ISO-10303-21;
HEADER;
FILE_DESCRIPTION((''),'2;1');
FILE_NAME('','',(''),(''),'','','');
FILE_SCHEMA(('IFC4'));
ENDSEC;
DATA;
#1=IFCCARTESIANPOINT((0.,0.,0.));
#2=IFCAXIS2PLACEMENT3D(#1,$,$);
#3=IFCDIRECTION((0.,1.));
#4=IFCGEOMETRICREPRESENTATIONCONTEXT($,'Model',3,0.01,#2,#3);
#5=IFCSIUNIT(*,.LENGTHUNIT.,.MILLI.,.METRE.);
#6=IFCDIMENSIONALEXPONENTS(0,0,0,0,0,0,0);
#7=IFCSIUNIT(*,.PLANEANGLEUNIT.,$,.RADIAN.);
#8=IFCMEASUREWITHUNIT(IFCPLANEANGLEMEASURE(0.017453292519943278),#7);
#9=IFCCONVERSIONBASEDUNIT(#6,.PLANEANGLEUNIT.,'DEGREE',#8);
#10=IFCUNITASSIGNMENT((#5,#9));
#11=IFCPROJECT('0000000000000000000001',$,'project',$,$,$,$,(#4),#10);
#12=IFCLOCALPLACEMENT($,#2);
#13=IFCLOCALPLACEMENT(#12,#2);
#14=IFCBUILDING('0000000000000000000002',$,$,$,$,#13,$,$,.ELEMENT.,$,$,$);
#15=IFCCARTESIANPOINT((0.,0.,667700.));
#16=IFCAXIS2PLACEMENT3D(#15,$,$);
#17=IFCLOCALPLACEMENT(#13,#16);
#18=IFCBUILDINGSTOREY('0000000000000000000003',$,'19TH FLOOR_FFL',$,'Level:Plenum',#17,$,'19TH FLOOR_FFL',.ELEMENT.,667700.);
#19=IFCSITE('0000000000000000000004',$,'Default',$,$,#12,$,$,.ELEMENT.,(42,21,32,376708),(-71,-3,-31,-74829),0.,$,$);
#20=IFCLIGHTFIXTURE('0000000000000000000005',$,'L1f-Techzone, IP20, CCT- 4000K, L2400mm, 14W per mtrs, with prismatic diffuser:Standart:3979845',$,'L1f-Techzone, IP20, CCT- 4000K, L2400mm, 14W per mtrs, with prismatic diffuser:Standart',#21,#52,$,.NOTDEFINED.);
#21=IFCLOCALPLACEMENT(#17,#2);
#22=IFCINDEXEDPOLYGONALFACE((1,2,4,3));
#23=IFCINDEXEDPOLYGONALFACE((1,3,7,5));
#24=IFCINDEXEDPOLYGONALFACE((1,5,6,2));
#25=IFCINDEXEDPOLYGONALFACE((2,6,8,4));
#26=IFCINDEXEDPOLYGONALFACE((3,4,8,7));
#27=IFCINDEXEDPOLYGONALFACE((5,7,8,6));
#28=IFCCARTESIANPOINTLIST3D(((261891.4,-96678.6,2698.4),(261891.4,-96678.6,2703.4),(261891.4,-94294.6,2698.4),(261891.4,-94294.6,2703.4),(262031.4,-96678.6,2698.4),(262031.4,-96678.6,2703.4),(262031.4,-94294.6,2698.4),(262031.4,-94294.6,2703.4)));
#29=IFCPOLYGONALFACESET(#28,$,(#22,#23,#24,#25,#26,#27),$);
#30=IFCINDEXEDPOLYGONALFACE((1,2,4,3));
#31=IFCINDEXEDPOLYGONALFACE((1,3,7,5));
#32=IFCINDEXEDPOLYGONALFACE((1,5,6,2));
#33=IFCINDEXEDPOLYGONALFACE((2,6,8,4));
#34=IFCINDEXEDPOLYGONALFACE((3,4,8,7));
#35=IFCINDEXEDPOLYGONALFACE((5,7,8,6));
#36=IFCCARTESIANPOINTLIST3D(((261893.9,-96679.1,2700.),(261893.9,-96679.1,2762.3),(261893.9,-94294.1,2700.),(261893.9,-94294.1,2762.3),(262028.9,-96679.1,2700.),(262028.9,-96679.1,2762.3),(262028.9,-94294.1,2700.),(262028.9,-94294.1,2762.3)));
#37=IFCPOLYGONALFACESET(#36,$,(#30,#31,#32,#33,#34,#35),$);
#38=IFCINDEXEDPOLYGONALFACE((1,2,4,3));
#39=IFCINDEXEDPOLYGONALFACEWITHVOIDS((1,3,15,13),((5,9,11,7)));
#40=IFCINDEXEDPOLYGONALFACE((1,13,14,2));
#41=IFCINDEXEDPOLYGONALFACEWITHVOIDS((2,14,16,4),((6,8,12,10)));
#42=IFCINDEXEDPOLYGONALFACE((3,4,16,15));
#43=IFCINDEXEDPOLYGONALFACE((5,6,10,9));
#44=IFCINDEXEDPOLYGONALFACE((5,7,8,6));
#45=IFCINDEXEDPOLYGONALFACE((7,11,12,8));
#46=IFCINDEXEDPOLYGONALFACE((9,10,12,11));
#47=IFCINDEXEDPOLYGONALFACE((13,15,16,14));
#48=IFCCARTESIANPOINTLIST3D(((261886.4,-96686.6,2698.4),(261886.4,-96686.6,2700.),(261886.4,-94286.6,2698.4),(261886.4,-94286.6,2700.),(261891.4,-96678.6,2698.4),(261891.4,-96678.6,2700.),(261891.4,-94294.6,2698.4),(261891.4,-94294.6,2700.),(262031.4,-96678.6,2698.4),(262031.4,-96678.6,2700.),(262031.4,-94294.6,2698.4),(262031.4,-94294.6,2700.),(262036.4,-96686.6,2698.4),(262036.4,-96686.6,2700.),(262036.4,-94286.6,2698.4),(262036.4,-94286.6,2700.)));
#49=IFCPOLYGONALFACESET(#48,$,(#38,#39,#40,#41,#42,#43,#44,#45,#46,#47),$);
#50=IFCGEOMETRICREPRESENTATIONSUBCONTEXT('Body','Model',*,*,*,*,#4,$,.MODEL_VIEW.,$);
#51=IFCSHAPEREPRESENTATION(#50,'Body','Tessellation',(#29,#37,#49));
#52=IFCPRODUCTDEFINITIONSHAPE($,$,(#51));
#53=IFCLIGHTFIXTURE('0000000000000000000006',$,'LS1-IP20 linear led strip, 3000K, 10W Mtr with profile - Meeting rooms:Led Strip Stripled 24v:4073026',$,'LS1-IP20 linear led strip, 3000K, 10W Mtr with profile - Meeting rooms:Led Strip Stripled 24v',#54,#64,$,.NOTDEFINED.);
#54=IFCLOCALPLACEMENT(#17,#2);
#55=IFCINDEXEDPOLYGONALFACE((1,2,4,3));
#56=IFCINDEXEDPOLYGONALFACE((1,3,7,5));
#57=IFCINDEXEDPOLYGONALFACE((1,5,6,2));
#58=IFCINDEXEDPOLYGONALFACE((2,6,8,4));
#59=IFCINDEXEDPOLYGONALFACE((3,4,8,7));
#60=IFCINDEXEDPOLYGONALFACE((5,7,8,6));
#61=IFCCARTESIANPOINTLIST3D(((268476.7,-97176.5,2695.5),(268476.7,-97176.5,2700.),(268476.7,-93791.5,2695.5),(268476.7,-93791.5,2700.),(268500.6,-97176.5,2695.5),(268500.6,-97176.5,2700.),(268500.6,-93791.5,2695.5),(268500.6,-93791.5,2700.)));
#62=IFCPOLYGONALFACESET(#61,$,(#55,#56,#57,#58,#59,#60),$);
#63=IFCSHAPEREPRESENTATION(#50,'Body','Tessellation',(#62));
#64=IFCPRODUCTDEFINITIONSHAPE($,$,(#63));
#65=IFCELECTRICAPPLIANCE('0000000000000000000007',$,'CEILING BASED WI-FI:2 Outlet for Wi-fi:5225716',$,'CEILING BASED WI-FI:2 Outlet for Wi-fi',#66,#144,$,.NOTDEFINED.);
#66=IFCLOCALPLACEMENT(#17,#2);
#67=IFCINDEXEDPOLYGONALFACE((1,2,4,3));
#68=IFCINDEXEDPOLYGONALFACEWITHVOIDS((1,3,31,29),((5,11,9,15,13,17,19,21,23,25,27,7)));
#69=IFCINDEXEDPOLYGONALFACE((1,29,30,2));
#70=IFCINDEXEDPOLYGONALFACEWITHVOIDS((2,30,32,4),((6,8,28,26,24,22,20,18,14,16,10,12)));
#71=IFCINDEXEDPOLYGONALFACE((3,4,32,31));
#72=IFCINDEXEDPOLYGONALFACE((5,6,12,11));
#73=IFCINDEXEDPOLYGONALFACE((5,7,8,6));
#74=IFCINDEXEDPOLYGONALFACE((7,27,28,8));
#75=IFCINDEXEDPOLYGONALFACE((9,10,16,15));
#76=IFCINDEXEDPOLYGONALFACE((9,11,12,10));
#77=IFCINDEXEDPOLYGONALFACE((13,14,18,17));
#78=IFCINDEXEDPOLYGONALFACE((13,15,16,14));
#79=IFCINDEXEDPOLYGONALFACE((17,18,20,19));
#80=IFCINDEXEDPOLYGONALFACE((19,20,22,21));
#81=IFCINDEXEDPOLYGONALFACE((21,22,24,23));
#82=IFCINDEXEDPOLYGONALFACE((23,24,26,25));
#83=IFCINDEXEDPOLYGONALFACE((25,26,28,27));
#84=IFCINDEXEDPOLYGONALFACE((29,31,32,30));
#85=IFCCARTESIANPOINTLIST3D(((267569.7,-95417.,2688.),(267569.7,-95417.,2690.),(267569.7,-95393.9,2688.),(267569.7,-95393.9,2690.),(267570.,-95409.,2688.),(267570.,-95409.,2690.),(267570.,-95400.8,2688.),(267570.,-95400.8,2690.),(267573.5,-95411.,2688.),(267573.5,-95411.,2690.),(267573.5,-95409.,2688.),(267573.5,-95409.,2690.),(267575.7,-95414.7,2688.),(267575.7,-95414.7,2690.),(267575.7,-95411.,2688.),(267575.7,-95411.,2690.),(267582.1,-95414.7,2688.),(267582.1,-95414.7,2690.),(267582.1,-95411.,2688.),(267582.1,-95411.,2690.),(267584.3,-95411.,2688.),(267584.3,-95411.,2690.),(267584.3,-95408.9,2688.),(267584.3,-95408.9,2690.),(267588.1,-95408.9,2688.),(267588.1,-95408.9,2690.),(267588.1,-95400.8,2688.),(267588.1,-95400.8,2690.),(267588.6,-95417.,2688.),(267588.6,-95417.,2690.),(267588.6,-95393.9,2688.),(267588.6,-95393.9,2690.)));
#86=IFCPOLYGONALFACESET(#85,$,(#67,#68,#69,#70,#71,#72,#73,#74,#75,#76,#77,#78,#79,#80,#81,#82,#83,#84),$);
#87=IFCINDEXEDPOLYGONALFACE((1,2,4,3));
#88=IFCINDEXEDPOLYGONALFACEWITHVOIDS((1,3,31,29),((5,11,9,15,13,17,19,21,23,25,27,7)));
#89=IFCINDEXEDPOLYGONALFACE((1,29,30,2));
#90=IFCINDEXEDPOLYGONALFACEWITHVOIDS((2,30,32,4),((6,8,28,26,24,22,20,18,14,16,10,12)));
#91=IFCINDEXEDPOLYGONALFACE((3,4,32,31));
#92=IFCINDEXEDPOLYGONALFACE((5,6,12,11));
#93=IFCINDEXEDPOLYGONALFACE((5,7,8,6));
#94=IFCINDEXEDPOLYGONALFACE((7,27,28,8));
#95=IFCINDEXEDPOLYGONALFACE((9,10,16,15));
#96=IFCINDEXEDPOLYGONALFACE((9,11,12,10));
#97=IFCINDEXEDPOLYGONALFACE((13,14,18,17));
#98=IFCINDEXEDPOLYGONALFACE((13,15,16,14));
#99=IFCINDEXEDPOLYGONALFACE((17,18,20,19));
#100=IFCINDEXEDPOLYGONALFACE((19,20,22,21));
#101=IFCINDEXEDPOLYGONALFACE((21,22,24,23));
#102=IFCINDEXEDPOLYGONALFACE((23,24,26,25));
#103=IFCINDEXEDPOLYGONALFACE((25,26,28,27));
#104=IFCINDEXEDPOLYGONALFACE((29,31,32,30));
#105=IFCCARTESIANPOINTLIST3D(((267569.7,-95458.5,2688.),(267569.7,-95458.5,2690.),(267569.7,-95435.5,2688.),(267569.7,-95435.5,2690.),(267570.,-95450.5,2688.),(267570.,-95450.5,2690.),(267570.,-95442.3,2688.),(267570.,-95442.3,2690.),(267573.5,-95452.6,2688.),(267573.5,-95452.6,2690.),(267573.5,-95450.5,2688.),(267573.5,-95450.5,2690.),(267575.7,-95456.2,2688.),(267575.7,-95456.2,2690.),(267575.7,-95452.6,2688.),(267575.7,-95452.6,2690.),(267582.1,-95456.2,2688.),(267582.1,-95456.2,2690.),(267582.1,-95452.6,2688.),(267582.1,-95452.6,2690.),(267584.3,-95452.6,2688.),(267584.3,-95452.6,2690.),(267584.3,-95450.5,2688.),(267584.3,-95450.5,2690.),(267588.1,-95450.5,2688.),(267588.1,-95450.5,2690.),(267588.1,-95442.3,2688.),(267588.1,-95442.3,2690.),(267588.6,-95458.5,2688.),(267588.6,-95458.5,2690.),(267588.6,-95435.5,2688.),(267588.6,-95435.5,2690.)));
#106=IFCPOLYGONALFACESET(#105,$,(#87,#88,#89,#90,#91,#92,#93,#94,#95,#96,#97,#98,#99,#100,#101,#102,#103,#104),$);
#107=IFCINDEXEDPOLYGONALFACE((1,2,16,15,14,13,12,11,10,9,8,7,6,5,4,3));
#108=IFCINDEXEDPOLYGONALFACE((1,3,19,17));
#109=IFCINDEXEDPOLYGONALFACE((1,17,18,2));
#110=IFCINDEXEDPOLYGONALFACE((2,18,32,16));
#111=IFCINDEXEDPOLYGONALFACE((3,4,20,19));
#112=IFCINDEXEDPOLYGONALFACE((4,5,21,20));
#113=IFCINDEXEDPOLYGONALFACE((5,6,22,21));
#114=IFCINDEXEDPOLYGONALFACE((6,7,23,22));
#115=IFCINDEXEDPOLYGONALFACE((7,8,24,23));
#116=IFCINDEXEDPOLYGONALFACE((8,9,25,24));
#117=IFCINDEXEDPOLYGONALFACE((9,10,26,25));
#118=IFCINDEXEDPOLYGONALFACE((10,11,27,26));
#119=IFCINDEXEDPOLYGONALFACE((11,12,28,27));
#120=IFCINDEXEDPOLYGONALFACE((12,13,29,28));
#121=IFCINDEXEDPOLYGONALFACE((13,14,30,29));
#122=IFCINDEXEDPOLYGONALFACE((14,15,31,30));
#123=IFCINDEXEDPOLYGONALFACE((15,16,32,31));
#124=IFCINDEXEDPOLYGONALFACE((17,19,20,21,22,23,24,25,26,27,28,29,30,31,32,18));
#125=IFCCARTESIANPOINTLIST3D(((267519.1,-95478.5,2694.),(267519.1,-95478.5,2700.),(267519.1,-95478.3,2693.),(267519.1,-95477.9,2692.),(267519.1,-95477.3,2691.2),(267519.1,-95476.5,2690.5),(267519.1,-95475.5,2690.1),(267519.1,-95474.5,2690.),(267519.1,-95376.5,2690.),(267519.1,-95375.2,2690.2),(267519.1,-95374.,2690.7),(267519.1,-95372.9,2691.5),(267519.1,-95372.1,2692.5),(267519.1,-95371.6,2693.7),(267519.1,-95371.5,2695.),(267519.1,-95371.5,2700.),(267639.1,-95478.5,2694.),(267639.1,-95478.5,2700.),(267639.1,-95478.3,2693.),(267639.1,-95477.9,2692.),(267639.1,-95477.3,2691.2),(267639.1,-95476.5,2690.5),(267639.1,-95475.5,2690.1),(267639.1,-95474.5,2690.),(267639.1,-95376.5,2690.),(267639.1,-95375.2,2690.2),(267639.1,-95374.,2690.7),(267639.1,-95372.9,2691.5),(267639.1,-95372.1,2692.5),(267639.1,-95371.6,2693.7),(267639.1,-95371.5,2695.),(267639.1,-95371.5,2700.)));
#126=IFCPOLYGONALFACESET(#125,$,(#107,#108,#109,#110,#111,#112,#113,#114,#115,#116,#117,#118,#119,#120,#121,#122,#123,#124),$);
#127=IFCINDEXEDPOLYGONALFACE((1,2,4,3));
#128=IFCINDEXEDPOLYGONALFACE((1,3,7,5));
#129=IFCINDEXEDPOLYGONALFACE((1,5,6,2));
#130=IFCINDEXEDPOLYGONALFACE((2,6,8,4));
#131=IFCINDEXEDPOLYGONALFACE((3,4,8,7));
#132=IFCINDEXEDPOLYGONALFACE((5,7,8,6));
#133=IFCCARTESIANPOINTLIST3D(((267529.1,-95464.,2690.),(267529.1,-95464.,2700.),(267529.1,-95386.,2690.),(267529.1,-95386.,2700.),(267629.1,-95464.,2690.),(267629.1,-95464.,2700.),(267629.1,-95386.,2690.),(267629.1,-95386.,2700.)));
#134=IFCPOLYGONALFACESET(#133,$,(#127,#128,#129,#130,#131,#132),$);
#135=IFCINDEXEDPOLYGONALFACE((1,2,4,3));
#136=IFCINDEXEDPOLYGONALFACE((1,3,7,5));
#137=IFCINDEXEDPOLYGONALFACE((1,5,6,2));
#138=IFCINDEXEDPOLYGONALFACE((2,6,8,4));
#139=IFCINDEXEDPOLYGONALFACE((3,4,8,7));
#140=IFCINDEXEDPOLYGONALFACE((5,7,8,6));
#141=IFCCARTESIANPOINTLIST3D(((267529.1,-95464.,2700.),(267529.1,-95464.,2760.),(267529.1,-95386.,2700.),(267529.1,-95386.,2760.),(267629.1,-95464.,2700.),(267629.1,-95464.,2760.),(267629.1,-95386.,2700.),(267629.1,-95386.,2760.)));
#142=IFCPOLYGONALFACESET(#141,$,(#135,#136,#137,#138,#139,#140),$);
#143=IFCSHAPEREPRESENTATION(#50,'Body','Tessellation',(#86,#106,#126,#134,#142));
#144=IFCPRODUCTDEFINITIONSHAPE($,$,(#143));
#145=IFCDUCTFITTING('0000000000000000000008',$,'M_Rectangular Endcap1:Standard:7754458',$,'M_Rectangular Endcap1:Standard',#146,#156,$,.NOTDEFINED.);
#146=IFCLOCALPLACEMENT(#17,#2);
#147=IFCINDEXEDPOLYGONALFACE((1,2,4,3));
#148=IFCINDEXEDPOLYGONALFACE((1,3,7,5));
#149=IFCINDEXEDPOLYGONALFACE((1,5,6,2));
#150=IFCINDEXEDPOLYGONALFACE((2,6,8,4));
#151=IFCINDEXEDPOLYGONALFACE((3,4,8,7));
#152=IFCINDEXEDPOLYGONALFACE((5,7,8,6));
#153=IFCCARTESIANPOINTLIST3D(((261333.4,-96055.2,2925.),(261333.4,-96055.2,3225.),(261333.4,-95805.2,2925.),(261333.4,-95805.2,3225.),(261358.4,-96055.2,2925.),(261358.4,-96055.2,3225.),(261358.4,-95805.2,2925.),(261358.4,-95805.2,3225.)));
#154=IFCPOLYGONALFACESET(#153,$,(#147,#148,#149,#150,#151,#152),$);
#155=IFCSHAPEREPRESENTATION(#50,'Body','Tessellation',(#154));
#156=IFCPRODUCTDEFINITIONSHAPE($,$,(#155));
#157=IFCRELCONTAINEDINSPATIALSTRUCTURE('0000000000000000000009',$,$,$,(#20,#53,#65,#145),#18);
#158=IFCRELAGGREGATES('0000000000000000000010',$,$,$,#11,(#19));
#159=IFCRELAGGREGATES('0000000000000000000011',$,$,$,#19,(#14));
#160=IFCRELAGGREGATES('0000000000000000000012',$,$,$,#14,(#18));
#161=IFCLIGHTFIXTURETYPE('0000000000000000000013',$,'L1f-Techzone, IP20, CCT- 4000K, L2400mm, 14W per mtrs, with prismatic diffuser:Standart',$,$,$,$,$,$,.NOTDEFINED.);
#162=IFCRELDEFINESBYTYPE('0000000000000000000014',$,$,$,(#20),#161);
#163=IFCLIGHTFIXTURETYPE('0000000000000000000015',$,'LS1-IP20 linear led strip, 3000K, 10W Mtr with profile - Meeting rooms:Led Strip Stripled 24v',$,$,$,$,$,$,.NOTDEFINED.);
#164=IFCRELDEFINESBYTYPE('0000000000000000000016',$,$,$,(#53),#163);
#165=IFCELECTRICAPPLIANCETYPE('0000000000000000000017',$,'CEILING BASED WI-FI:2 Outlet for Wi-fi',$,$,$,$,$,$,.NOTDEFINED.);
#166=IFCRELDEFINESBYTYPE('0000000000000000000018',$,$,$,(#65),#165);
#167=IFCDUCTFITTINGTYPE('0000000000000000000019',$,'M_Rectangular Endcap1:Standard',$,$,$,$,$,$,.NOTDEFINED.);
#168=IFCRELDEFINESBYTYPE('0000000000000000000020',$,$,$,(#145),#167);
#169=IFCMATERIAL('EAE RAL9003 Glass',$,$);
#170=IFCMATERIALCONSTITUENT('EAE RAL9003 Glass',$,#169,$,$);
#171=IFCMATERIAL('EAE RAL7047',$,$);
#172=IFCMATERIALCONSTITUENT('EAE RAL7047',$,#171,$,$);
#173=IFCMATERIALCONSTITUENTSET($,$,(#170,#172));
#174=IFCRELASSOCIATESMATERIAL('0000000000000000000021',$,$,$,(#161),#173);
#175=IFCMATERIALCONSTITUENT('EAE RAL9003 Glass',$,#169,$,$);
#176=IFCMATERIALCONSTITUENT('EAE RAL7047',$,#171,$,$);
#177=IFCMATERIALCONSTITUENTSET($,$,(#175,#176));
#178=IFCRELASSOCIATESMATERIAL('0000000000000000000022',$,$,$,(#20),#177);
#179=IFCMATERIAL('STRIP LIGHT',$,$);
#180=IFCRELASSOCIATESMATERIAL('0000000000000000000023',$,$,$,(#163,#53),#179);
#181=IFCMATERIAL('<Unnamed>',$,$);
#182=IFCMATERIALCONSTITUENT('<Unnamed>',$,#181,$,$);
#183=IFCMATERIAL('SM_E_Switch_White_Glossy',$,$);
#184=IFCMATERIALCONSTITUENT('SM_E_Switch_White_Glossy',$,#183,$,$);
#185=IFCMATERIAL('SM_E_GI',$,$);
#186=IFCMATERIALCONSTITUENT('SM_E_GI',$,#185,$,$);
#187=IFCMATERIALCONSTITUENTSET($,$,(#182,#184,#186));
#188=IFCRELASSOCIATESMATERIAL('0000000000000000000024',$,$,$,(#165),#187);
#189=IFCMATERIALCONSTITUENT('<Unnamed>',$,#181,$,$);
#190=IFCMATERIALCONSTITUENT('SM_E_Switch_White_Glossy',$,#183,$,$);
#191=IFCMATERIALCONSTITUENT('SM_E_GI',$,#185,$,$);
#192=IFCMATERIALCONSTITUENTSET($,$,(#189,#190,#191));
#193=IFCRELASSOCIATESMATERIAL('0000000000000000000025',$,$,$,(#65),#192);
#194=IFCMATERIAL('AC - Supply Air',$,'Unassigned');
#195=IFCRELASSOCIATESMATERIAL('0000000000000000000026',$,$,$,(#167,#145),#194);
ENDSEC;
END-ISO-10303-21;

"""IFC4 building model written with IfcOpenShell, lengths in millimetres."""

from ifc_helpers import new_model, entity, si_unit, converted_unit, direction, frame, origin, place, context, subcontext, project, spatial, line, arc, indexed_curve, outline, extrude, source, transform, mapped, material, constituent, constituent_set, type_object, type_shapes, element, save


model = new_model("IFC4")

# Units and contexts
model_context = context("Model", 3, precision=0.01, world=origin(), true_north=direction((0.0, 1.0)))
body_context = subcontext(model_context, "Body", "Model", "MODEL_VIEW")
ifc_project = project(units=[si_unit("LENGTHUNIT", "METRE", prefix="MILLI"), converted_unit("PLANEANGLEUNIT", "DEGREE", entity("IfcPlaneAngleMeasure", 0.017453292519943278), si_unit("PLANEANGLEUNIT", "RADIAN"), dimensions=[0, 0, 0, 0, 0, 0, 0])], contexts=[model_context])

# Site, building, storey
site_placement = place(None, origin())
site = spatial("IfcSite", under=ifc_project, at=site_placement, Name="Default", CompositionType="ELEMENT", RefLatitude=(42, 21, 32, 376708), RefLongitude=(-71, -3, -31, -74829), RefElevation=0.0)
building_placement = place(site_placement, origin())
building = spatial("IfcBuilding", under=site, at=building_placement, CompositionType="ELEMENT")
storey_placement = place(building_placement, frame((0.0, 0.0, 667700.0)))
storey = spatial("IfcBuildingStorey", under=building, at=storey_placement, Name="19TH FLOOR_FFL", ObjectType="Level:Plenum", LongName="19TH FLOOR_FFL", CompositionType="ELEMENT", Elevation=667700.0)

# Light fixtures
ifc_material_1 = material(Name="EAE RAL9003 Glass")
ifc_material_2 = material(Name="EAE RAL7047")
ifc_constituent_1 = constituent(ifc_material_1, Name="EAE RAL9003 Glass")
ifc_constituent_2 = constituent(ifc_material_2, Name="EAE RAL7047")
ifc_constituent_set_1 = constituent_set(constituents=[ifc_constituent_1, ifc_constituent_2])
light_fixture_type_1 = type_object("IfcLightFixtureType", Name="L1f-Techzone, IP20, CCT- 4000K, L2400mm, 14W per mtrs, with prismatic diffuser:Standart", PredefinedType="NOTDEFINED", material=ifc_constituent_set_1)
shared_shape_1 = source(origin(), body_context, "Body", "SweptSolid", [
    extrude(outline(indexed_curve([(-70.0, -1192.0), (70.0, -1192.0), (70.0, 1192.0), (-70.0, 1192.0), (-70.0, -1192.0)], self_intersect=False)), frame((0.0, 0.0, -3.4), z_axis=(0.0, 0.0, 1.0), x_axis=(-1.0, 0.0, 0.0)), (0.0, 0.0, 1.0), 5.0),
    extrude(outline(indexed_curve([(-67.5, -1192.5), (67.5, -1192.5), (67.5, 1192.5), (-67.5, 1192.5), (-67.5, -1192.5)], self_intersect=False)), frame((0.0, 0.0, -62.3), z_axis=(0.0, 0.0, 1.0), x_axis=(-1.0, 0.0, 0.0)), (0.0, 0.0, 1.0), 62.3),
    extrude(outline(indexed_curve([(-75.0, -1200.0), (75.0, -1200.0), (75.0, 1200.0), (-75.0, 1200.0), (-75.0, -1200.0)], self_intersect=False), holes=[indexed_curve([(-70.0, -1192.0), (-70.0, 1192.0), (70.0, 1192.0), (70.0, -1192.0), (-70.0, -1192.0)], self_intersect=False)]), frame((0.0, 0.0, 0.0), z_axis=(0.0, 0.0, 1.0), x_axis=(-1.0, 0.0, 0.0)), (0.0, 0.0, 1.0), 1.6),
])
type_shapes(light_fixture_type_1, [shared_shape_1])
ifc_constituent_3 = constituent(ifc_material_1, Name="EAE RAL9003 Glass")
ifc_constituent_4 = constituent(ifc_material_2, Name="EAE RAL7047")
ifc_constituent_set_2 = constituent_set(constituents=[ifc_constituent_3, ifc_constituent_4])
light_fixture_1_placement = place(storey_placement, frame((261961.4, -95486.6, 2700.0), z_axis=(0.0, 0.0, -1.0), x_axis=(1.0, 0.0, 0.0)))
element("IfcLightFixture", 1, at=light_fixture_1_placement, inside=storey, type_object=light_fixture_type_1, material=ifc_constituent_set_2, Name="L1f-Techzone, IP20, CCT- 4000K, L2400mm, 14W per mtrs, with prismatic diffuser:Standart:3979845", ObjectType="L1f-Techzone, IP20, CCT- 4000K, L2400mm, 14W per mtrs, with prismatic diffuser:Standart", PredefinedType="NOTDEFINED", context=body_context, shape_type="MappedRepresentation", body=[
    mapped(shared_shape_1, transform((0.0, 0.0, 0.0), scale=1.0)),
])
ifc_material_3 = material(Name="STRIP LIGHT")
light_fixture_type_2 = type_object("IfcLightFixtureType", Name="LS1-IP20 linear led strip, 3000K, 10W Mtr with profile - Meeting rooms:Led Strip Stripled 24v", PredefinedType="NOTDEFINED", material=ifc_material_3)
shared_shape_2 = source(origin(), body_context, "Body", "SweptSolid", [
    extrude(outline(indexed_curve([(-11.9, -1692.5), (11.9, -1692.5), (11.9, 1692.5), (-11.9, 1692.5), (-11.9, -1692.5)], self_intersect=False)), frame((0.0, 0.3, 0.0), z_axis=(0.0, 0.0, 1.0), x_axis=(0.0, -1.0, 0.0)), (0.0, 0.0, 1.0), 4.5),
])
type_shapes(light_fixture_type_2, [shared_shape_2])
light_fixture_2_placement = place(storey_placement, frame((268489.0, -95484.0, 2700.0), z_axis=(0.0, 0.0, -1.0), x_axis=(0.0, -1.0, 0.0)))
element("IfcLightFixture", 2, at=light_fixture_2_placement, inside=storey, type_object=light_fixture_type_2, material=ifc_material_3, Name="LS1-IP20 linear led strip, 3000K, 10W Mtr with profile - Meeting rooms:Led Strip Stripled 24v:4073026", ObjectType="LS1-IP20 linear led strip, 3000K, 10W Mtr with profile - Meeting rooms:Led Strip Stripled 24v", PredefinedType="NOTDEFINED", context=body_context, shape_type="MappedRepresentation", body=[
    mapped(shared_shape_2, transform((0.0, 0.0, 0.0), scale=1.0)),
])

# Electric appliance
ifc_material_4 = material(Name="<Unnamed>")
ifc_constituent_5 = constituent(ifc_material_4, Name="<Unnamed>")
ifc_material_5 = material(Name="SM_E_Switch_White_Glossy")
ifc_constituent_6 = constituent(ifc_material_5, Name="SM_E_Switch_White_Glossy")
ifc_material_6 = material(Name="SM_E_GI")
ifc_constituent_7 = constituent(ifc_material_6, Name="SM_E_GI")
ifc_constituent_set_3 = constituent_set(constituents=[ifc_constituent_5, ifc_constituent_6, ifc_constituent_7])
ifc_constituent_8 = constituent(ifc_material_4, Name="<Unnamed>")
ifc_constituent_9 = constituent(ifc_material_5, Name="SM_E_Switch_White_Glossy")
ifc_constituent_10 = constituent(ifc_material_6, Name="SM_E_GI")
ifc_constituent_set_4 = constituent_set(constituents=[ifc_constituent_8, ifc_constituent_9, ifc_constituent_10])
electric_appliance_type = type_object("IfcElectricApplianceType", Name="CEILING BASED WI-FI:2 Outlet for Wi-fi", PredefinedType="NOTDEFINED", material=ifc_constituent_set_4)
shared_shape_3 = source(origin(), body_context, "Body", "SweptSolid", [
    extrude(outline(indexed_curve([(-11.5, -9.5), (11.5, -9.5), (11.5, 9.5), (-11.5, 9.5), (-11.5, -9.5)], self_intersect=False), holes=[indexed_curve([(3.5, 9.1), (3.5, 5.6), (5.5, 5.6), (5.5, 3.4), (9.2, 3.4), (9.2, -3.0), (5.5, -3.0), (5.5, -5.2), (3.4, -5.2), (3.4, -8.9), (-4.7, -8.9), (-4.7, 9.1), (3.5, 9.1)], self_intersect=False)]), frame((0.0, -73.0, 10.0), z_axis=(0.0, 0.0, 1.0), x_axis=(0.0, 1.0, 0.0)), (0.0, 0.0, 1.0), 2.0),
    extrude(outline(indexed_curve([(-11.5, -9.5), (11.5, -9.5), (11.5, 9.5), (-11.5, 9.5), (-11.5, -9.5)], self_intersect=False), holes=[indexed_curve([(3.5, 9.1), (3.5, 5.6), (5.5, 5.6), (5.5, 3.4), (9.2, 3.4), (9.2, -3.0), (5.5, -3.0), (5.5, -5.2), (3.4, -5.2), (3.4, -8.9), (-4.7, -8.9), (-4.7, 9.1), (3.5, 9.1)], self_intersect=False)]), frame((0.0, -31.4, 10.0), z_axis=(0.0, 0.0, 1.0), x_axis=(0.0, 1.0, 0.0)), (0.0, 0.0, 1.0), 2.0),
    extrude(outline(indexed_curve([(-53.7, -5.2), (53.3, -5.2), (53.3, 0.8), (52.2, 3.7), (49.3, 4.8), (-48.7, 4.8), (-52.2, 3.4), (-53.7, -0.2)], segments=[line(1, 2, 3), arc(3, 4, 5), line(5, 6), arc(6, 7, 8), line(8, 1)], self_intersect=False)), frame((-60.0, -53.3, 5.2), z_axis=(1.0, 0.0, 0.0), x_axis=(0.0, 1.0, 0.0)), (0.0, 0.0, 1.0), 120.0),
    extrude(outline(indexed_curve([(-50.0, -39.0), (50.0, -39.0), (50.0, 39.0), (-50.0, 39.0), (-50.0, -39.0)], self_intersect=False)), frame((0.0, -53.5, 0.0), z_axis=(0.0, 0.0, 1.0), x_axis=(-1.0, 0.0, 0.0)), (0.0, 0.0, 1.0), 10.0),
    extrude(outline(indexed_curve([(-50.0, -39.0), (50.0, -39.0), (50.0, 39.0), (-50.0, 39.0), (-50.0, -39.0)], self_intersect=False)), frame((0.0, -53.5, -60.0), z_axis=(0.0, 0.0, 1.0), x_axis=(-1.0, 0.0, 0.0)), (0.0, 0.0, 1.0), 60.0),
])
type_shapes(electric_appliance_type, [shared_shape_3])
electric_appliance_placement = place(storey_placement, frame((267579.1, -95478.5, 2700.0), z_axis=(0.0, 0.0, -1.0), x_axis=(1.0, 0.0, 0.0)))
element("IfcElectricAppliance", 3, at=electric_appliance_placement, inside=storey, type_object=electric_appliance_type, material=ifc_constituent_set_3, Name="CEILING BASED WI-FI:2 Outlet for Wi-fi:5225716", ObjectType="CEILING BASED WI-FI:2 Outlet for Wi-fi", PredefinedType="NOTDEFINED", context=body_context, shape_type="MappedRepresentation", body=[
    mapped(shared_shape_3, transform((0.0, 0.0, 0.0), scale=1.0)),
])

# Duct fitting
ifc_material_7 = material(Name="AC - Supply Air", Category="Unassigned")
duct_fitting_type_1 = type_object("IfcDuctFittingType", Name="M_Rectangular Endcap1:Standard", PredefinedType="NOTDEFINED", material=ifc_material_7)
shared_shape_4 = source(origin(), body_context, "Body", "SweptSolid", [
    extrude(outline(indexed_curve([(-12.5, -125.0), (12.5, -125.0), (12.5, 125.0), (-12.5, 125.0), (-12.5, -125.0)], self_intersect=False)), frame((12.5, 0.0, -150.0)), (0.0, 0.0, 1.0), 300.0),
])
type_shapes(duct_fitting_type_1, [shared_shape_4])
duct_fitting_1_placement = place(storey_placement, frame((261358.4, -95930.2, 3075.0), z_axis=(0.0, 0.0, 1.0), x_axis=(-1.0, 0.0, 0.0)))
element("IfcDuctFitting", 4, at=duct_fitting_1_placement, inside=storey, type_object=duct_fitting_type_1, material=ifc_material_7, Name="M_Rectangular Endcap1:Standard:7754458", ObjectType="M_Rectangular Endcap1:Standard", PredefinedType="NOTDEFINED", context=body_context, shape_type="MappedRepresentation", body=[
    mapped(shared_shape_4, transform((0.0, 0.0, 0.0), scale=1.0)),
])

save(model, "model.ifc")
